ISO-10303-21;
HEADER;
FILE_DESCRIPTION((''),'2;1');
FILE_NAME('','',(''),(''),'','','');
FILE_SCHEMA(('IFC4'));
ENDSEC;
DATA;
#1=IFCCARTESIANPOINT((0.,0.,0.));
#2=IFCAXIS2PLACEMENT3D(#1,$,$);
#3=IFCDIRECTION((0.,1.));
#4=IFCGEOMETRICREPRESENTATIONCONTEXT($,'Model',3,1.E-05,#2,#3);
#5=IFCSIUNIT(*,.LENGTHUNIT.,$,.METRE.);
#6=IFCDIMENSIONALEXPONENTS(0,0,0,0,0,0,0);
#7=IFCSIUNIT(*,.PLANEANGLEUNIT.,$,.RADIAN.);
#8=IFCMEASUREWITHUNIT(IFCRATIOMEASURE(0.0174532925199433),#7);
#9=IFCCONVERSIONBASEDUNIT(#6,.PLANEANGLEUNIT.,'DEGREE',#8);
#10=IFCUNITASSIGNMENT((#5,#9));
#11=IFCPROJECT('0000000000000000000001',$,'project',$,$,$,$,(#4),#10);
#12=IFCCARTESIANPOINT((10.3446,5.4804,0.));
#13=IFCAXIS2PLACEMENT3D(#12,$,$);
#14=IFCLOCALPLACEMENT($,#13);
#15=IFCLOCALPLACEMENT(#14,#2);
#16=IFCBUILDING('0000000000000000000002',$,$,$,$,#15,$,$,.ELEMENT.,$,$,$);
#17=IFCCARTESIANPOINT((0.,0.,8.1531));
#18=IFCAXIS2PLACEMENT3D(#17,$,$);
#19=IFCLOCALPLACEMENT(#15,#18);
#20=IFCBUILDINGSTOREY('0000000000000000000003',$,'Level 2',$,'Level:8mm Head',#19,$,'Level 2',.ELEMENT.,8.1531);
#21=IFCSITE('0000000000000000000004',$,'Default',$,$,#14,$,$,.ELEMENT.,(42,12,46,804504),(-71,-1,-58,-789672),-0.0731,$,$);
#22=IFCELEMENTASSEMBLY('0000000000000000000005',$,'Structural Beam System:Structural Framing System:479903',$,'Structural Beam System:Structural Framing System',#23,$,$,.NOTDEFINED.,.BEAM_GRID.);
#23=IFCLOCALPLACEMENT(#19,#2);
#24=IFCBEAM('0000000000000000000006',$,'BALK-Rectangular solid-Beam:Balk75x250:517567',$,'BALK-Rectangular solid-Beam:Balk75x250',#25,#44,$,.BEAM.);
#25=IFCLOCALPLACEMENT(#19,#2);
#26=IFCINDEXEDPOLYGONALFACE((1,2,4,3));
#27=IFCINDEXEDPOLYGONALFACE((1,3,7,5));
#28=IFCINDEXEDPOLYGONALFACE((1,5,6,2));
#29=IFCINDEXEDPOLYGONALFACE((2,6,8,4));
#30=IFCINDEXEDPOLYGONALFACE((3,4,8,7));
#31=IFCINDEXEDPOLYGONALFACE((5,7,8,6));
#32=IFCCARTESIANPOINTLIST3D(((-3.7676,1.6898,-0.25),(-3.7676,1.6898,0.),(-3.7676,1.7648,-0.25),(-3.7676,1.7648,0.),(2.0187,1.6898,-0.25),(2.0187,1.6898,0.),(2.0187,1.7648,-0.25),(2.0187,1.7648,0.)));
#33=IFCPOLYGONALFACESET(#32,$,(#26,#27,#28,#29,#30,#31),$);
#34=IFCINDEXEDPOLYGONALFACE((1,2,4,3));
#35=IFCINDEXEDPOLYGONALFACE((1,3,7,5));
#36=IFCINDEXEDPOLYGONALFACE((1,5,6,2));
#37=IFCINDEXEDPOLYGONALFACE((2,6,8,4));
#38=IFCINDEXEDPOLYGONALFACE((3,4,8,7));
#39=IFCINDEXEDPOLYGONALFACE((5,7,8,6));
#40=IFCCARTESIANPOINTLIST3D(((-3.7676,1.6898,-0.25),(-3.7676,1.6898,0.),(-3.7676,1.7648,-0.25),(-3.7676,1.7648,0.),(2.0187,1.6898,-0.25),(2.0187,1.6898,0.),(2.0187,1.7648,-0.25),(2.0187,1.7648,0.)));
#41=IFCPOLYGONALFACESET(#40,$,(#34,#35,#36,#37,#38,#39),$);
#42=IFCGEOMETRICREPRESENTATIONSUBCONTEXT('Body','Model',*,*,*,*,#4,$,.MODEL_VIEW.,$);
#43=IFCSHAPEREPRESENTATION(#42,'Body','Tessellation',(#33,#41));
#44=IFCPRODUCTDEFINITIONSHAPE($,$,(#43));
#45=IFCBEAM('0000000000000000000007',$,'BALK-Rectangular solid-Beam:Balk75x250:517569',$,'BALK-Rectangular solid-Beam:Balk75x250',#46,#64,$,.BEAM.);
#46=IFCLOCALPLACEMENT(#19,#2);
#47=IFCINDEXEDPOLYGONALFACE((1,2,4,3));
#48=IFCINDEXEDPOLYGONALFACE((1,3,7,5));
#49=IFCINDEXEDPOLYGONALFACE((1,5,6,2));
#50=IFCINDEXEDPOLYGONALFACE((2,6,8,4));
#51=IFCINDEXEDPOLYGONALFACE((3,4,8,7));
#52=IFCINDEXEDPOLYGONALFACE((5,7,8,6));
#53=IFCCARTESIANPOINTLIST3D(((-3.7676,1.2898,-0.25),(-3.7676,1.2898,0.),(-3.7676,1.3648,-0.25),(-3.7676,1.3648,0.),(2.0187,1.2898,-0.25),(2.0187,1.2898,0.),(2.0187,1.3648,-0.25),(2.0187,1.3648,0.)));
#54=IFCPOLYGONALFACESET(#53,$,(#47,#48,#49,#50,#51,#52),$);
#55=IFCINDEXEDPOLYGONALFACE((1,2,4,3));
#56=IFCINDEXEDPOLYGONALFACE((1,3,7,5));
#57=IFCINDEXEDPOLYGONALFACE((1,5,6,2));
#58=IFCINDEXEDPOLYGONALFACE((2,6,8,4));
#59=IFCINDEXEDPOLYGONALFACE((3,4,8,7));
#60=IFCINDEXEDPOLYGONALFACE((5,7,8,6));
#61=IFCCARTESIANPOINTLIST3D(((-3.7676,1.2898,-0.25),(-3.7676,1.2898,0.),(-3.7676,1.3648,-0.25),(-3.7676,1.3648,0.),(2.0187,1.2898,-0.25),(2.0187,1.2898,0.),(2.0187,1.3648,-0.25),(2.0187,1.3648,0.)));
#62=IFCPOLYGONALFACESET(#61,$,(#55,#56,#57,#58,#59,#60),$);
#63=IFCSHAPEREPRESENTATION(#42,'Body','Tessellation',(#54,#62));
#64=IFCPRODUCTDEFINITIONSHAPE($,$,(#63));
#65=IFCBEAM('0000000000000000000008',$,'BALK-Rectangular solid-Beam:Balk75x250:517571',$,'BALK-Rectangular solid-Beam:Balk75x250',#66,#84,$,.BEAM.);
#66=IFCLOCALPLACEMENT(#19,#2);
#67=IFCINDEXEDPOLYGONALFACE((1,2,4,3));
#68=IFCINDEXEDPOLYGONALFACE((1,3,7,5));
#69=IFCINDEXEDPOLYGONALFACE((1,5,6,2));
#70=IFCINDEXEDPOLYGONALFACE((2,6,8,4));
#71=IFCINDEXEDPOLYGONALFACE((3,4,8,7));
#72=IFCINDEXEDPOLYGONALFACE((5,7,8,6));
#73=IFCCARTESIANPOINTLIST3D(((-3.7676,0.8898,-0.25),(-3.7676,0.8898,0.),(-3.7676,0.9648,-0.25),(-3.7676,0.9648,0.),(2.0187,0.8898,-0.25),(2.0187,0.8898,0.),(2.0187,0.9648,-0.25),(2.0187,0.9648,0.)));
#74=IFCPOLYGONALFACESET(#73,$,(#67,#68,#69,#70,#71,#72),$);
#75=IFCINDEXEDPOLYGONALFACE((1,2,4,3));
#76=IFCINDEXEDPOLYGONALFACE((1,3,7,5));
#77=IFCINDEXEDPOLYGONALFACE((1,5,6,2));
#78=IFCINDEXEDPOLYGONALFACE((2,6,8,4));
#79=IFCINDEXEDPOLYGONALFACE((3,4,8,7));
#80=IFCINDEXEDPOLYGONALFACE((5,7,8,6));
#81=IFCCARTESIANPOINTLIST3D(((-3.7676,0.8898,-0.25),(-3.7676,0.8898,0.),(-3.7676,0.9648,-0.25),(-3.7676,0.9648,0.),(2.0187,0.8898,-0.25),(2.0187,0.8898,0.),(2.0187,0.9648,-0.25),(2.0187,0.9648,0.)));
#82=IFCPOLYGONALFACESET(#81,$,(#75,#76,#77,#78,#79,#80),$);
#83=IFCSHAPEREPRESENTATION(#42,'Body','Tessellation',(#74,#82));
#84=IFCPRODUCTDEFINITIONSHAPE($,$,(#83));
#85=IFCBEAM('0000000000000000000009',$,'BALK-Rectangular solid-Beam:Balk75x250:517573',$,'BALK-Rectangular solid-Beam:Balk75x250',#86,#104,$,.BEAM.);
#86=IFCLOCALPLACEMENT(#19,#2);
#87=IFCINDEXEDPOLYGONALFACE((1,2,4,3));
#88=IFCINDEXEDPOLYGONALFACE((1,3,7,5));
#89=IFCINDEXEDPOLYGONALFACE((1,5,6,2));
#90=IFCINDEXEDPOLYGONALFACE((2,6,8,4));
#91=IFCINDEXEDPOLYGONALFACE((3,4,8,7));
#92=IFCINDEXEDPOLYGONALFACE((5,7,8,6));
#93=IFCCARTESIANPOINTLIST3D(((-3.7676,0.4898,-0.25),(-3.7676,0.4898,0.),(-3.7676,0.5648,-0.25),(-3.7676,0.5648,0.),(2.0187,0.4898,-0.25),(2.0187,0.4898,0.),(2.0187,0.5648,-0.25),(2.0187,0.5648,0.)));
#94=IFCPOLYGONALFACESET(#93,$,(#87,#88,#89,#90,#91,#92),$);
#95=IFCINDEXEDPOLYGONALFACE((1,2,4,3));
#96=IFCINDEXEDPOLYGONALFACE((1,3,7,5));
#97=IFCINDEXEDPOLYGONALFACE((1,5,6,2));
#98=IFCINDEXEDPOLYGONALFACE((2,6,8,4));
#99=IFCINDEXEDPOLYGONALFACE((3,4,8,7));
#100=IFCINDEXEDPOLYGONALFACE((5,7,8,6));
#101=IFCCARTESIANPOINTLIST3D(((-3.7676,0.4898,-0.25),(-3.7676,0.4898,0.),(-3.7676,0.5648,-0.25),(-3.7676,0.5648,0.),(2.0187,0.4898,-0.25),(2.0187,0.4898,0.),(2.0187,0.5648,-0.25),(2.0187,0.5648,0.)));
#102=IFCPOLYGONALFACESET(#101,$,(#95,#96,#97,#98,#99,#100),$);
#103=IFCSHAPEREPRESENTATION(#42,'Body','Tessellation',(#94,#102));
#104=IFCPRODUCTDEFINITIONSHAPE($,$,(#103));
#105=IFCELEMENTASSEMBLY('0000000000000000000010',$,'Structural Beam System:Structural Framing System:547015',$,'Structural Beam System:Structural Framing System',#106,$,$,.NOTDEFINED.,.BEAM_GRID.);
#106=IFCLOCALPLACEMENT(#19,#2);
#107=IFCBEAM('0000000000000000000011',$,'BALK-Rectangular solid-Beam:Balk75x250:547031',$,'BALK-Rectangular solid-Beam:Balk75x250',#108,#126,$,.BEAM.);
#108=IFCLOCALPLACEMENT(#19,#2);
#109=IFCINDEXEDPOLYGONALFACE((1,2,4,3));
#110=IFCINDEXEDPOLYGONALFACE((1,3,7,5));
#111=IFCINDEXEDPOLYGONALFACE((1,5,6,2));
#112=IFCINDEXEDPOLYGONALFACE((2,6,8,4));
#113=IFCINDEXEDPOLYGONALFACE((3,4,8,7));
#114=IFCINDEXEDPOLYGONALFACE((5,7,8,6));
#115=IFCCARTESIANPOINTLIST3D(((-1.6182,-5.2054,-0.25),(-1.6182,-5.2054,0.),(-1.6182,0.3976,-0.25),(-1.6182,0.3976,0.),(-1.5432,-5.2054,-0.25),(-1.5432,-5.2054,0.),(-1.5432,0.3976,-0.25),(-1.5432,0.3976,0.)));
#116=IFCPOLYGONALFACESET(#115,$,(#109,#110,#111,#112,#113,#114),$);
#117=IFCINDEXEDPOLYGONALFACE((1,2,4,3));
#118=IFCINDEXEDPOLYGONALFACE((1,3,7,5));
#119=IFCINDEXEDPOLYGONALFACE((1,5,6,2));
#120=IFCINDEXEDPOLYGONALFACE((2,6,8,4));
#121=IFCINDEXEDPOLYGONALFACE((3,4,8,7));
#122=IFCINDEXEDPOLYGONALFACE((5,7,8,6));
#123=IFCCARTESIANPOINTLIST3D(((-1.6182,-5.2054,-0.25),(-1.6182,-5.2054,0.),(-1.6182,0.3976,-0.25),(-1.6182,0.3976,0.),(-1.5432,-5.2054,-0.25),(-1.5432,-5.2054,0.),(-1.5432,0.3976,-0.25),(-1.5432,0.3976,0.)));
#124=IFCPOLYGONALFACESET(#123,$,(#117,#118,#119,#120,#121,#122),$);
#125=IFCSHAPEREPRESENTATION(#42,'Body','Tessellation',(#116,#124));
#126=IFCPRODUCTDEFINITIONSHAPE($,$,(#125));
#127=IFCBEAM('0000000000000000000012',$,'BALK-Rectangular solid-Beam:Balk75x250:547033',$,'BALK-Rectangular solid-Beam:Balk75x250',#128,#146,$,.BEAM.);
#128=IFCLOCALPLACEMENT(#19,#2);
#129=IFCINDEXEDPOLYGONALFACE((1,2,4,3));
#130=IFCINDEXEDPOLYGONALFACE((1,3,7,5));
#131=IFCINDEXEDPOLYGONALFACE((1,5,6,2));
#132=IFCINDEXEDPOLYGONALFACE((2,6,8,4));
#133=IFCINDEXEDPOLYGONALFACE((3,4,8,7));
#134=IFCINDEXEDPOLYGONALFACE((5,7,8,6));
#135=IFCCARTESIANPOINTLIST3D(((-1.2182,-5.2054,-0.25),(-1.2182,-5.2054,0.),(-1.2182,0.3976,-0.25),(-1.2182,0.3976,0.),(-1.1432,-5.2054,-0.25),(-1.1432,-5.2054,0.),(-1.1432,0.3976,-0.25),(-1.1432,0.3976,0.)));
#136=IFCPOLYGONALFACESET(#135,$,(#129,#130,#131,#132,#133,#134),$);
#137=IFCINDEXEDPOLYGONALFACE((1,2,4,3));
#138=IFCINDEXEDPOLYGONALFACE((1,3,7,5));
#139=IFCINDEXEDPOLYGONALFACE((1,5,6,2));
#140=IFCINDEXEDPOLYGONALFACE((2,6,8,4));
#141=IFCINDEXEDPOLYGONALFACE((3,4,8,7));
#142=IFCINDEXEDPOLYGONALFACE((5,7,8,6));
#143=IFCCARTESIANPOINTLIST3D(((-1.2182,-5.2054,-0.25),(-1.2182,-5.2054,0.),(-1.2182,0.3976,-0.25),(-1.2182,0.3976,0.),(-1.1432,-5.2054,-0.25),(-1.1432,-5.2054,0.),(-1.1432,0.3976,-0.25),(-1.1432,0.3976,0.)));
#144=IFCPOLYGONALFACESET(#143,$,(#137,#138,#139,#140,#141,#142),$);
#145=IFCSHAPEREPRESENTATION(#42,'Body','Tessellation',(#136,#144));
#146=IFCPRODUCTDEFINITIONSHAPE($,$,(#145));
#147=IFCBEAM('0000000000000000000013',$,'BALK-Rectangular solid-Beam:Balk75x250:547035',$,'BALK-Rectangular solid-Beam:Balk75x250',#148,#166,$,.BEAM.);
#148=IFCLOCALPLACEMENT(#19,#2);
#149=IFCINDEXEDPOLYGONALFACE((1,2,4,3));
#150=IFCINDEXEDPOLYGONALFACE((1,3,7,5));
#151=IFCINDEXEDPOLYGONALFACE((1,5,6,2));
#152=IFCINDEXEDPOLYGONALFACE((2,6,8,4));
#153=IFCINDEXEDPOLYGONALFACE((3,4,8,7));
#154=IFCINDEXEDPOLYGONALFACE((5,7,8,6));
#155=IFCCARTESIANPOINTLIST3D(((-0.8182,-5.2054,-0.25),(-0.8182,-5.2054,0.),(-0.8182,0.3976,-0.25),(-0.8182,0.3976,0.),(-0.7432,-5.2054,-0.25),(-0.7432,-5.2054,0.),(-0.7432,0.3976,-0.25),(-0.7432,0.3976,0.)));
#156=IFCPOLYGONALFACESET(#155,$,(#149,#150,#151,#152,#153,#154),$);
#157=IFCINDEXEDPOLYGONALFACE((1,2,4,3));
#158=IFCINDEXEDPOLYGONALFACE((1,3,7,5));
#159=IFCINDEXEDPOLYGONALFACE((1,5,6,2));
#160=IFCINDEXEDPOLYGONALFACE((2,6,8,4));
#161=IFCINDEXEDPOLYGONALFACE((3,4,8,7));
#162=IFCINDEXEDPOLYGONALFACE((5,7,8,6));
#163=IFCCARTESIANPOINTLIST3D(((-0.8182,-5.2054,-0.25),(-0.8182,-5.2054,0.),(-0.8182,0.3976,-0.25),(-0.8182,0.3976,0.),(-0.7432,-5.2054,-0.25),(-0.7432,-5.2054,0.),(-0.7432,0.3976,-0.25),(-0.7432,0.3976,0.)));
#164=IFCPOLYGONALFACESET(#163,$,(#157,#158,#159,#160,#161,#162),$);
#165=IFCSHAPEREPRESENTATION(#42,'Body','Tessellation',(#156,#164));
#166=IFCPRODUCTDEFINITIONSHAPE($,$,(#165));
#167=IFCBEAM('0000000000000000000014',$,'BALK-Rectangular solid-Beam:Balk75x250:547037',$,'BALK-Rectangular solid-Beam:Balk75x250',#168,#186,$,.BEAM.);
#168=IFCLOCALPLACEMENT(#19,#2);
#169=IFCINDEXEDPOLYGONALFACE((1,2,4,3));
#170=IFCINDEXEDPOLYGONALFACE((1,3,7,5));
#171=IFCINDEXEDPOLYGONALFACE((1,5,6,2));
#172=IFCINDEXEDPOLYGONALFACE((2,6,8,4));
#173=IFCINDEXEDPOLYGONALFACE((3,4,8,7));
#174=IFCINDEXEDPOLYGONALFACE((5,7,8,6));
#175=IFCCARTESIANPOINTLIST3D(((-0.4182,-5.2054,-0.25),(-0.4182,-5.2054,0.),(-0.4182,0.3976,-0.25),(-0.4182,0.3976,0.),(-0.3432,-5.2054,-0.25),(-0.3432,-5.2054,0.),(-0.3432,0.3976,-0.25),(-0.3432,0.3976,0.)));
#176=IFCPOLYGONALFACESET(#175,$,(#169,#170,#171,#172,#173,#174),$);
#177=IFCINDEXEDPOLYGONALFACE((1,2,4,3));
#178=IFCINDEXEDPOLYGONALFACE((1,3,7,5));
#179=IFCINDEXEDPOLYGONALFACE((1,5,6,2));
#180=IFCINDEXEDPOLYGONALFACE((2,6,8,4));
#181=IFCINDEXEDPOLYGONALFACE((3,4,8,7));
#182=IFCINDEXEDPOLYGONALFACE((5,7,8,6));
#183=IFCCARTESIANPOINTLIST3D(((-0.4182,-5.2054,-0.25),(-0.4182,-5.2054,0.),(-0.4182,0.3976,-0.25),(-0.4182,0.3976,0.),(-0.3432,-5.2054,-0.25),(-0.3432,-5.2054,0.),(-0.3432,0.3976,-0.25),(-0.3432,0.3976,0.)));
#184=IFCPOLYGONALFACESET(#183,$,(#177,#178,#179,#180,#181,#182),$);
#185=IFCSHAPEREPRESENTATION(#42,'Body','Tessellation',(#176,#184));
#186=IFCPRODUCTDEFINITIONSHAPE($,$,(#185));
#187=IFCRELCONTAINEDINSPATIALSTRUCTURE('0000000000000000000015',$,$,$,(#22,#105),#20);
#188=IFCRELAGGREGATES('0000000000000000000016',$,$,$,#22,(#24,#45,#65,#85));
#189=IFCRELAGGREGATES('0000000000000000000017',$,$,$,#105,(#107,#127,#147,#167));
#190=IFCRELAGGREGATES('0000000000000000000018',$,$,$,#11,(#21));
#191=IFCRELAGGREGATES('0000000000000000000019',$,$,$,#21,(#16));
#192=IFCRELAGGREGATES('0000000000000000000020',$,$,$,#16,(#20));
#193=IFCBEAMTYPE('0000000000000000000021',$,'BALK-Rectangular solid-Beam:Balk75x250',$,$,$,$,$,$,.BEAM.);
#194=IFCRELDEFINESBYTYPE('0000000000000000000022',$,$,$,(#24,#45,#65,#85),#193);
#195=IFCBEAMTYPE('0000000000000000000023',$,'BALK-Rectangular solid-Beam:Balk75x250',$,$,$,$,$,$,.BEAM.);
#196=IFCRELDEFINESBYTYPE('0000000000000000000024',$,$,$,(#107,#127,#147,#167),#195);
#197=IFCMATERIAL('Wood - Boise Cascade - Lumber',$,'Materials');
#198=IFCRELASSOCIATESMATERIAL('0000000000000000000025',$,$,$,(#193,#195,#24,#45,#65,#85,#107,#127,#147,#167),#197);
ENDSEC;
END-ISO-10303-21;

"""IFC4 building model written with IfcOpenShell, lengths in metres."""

from ifc_helpers import new_model, entity, si_unit, converted_unit, direction, frame, frame_2d, origin, origin_2d_with_axis, place, context, subcontext, project, spatial, rectangle, extrude, source, transform, mapped, material, material_profile, profile_set, profile_usage, type_object, type_shapes, element, aggregate, save


model = new_model("IFC4")

# Units and contexts
model_context = context("Model", 3, precision=1e-05, world=origin(), true_north=direction((0.0, 1.0)))
body_context = subcontext(model_context, "Body", "Model", "MODEL_VIEW")
ifc_project = project(units=[si_unit("LENGTHUNIT", "METRE"), converted_unit("PLANEANGLEUNIT", "DEGREE", entity("IfcRatioMeasure", 0.0174532925199433), si_unit("PLANEANGLEUNIT", "RADIAN"), dimensions=[0, 0, 0, 0, 0, 0, 0])], contexts=[model_context])

# Site, building, storey
site_placement = place(None, frame((10.3446, 5.4804, 0.0)))
site = spatial("IfcSite", under=ifc_project, at=site_placement, Name="Default", CompositionType="ELEMENT", RefLatitude=(42, 12, 46, 804504), RefLongitude=(-71, -1, -58, -789672), RefElevation=-0.0731)
building_placement = place(site_placement, origin())
building = spatial("IfcBuilding", under=site, at=building_placement, CompositionType="ELEMENT")
storey_placement = place(building_placement, frame((0.0, 0.0, 8.1531)))
storey = spatial("IfcBuildingStorey", under=building, at=storey_placement, Name="Level 2", ObjectType="Level:8mm Head", LongName="Level 2", CompositionType="ELEMENT", Elevation=8.1531)

# Element assemblies, beams
ifc_material = material(Name="Wood - Boise Cascade - Lumber", Category="Materials")
ifc_material_profile = material_profile(ifc_material, rectangle(XDim=0.25, YDim=0.075, at=frame_2d((0.0, 0.0), x_axis=(1.0, 0.0))), Name="Balk75x250")
ifc_profile_set = profile_set([ifc_material_profile], Name="Balk75x250")
assembly_1_placement = place(storey_placement, origin())
assembly_1 = element("IfcElementAssembly", 1, at=assembly_1_placement, inside=storey, Name="Structural Beam System:Structural Framing System:479903", ObjectType="Structural Beam System:Structural Framing System", AssemblyPlace="NOTDEFINED", PredefinedType="BEAM_GRID")
beam_type_1 = type_object("IfcBeamType", Name="BALK-Rectangular solid-Beam:Balk75x250", PredefinedType="BEAM", material=ifc_profile_set)
shared_shape_1 = source(origin(), body_context, "Body", "SweptSolid", [
    extrude(rectangle(XDim=0.25, YDim=0.075, at=origin_2d_with_axis()), frame((-2.9869, 0.0, 0.0), z_axis=(1.0, 0.0, 0.0), x_axis=(0.0, 0.0, -1.0)), (0.0, 0.0, 1.0), 5.7863),
    extrude(rectangle(XDim=0.25, YDim=0.075, at=origin_2d_with_axis()), frame((-2.9869, 0.0, 0.0), z_axis=(1.0, 0.0, 0.0), x_axis=(0.0, 0.0, -1.0)), (0.0, 0.0, 1.0), 5.7863),
])
type_shapes(beam_type_1, [shared_shape_1])
ifc_profile_usage_1 = profile_usage(ifc_profile_set, cardinal=8)
beam_1_placement = place(assembly_1_placement, frame((-0.7807, 1.7273, -0.125)))
beam_1 = element("IfcBeam", 2, at=beam_1_placement, type_object=beam_type_1, material=ifc_profile_usage_1, Name="BALK-Rectangular solid-Beam:Balk75x250:517567", ObjectType="BALK-Rectangular solid-Beam:Balk75x250", PredefinedType="BEAM", context=body_context, shape_type="MappedRepresentation", body=[
    mapped(shared_shape_1, transform((0.0, 0.0, 0.0), scale=1.0)),
])
ifc_profile_usage_2 = profile_usage(ifc_profile_set, cardinal=8)
beam_2_placement = place(assembly_1_placement, frame((-0.7807, 1.3273, -0.125)))
beam_2 = element("IfcBeam", 3, at=beam_2_placement, type_object=beam_type_1, material=ifc_profile_usage_2, Name="BALK-Rectangular solid-Beam:Balk75x250:517569", ObjectType="BALK-Rectangular solid-Beam:Balk75x250", PredefinedType="BEAM", context=body_context, shape_type="MappedRepresentation", body=[
    mapped(shared_shape_1, transform((0.0, 0.0, 0.0), scale=1.0)),
])
ifc_profile_usage_3 = profile_usage(ifc_profile_set, cardinal=8)
beam_3_placement = place(assembly_1_placement, frame((-0.7807, 0.9273, -0.125)))
beam_3 = element("IfcBeam", 4, at=beam_3_placement, type_object=beam_type_1, material=ifc_profile_usage_3, Name="BALK-Rectangular solid-Beam:Balk75x250:517571", ObjectType="BALK-Rectangular solid-Beam:Balk75x250", PredefinedType="BEAM", context=body_context, shape_type="MappedRepresentation", body=[
    mapped(shared_shape_1, transform((0.0, 0.0, 0.0), scale=1.0)),
])
ifc_profile_usage_4 = profile_usage(ifc_profile_set, cardinal=8)
beam_4_placement = place(assembly_1_placement, frame((-0.7807, 0.5273, -0.125)))
beam_4 = element("IfcBeam", 5, at=beam_4_placement, type_object=beam_type_1, material=ifc_profile_usage_4, Name="BALK-Rectangular solid-Beam:Balk75x250:517573", ObjectType="BALK-Rectangular solid-Beam:Balk75x250", PredefinedType="BEAM", context=body_context, shape_type="MappedRepresentation", body=[
    mapped(shared_shape_1, transform((0.0, 0.0, 0.0), scale=1.0)),
])
aggregate(assembly_1, [beam_1, beam_2, beam_3, beam_4])
assembly_2_placement = place(storey_placement, origin())
assembly_2 = element("IfcElementAssembly", 6, at=assembly_2_placement, inside=storey, Name="Structural Beam System:Structural Framing System:547015", ObjectType="Structural Beam System:Structural Framing System", AssemblyPlace="NOTDEFINED", PredefinedType="BEAM_GRID")
ifc_profile_usage_5 = profile_usage(ifc_profile_set, cardinal=8)
beam_type_2 = type_object("IfcBeamType", Name="BALK-Rectangular solid-Beam:Balk75x250", PredefinedType="BEAM", material=ifc_profile_set)
shared_shape_2 = source(origin(), body_context, "Body", "SweptSolid", [
    extrude(rectangle(XDim=0.25, YDim=0.075, at=origin_2d_with_axis()), frame((-2.6953, 0.0, 0.0), z_axis=(1.0, 0.0, 0.0), x_axis=(0.0, 0.0, -1.0)), (0.0, 0.0, 1.0), 5.603),
    extrude(rectangle(XDim=0.25, YDim=0.075, at=origin_2d_with_axis()), frame((-2.6953, 0.0, 0.0), z_axis=(1.0, 0.0, 0.0), x_axis=(0.0, 0.0, -1.0)), (0.0, 0.0, 1.0), 5.603),
])
type_shapes(beam_type_2, [shared_shape_2])
beam_5_placement = place(assembly_2_placement, frame((-1.5807, -2.5102, -0.125), z_axis=(0.0, 0.0, 1.0), x_axis=(0.0, 1.0, 0.0)))
beam_5 = element("IfcBeam", 7, at=beam_5_placement, type_object=beam_type_2, material=ifc_profile_usage_5, Name="BALK-Rectangular solid-Beam:Balk75x250:547031", ObjectType="BALK-Rectangular solid-Beam:Balk75x250", PredefinedType="BEAM", context=body_context, shape_type="MappedRepresentation", body=[
    mapped(shared_shape_2, transform((0.0, 0.0, 0.0), scale=1.0)),
])
ifc_profile_usage_6 = profile_usage(ifc_profile_set, cardinal=8)
beam_6_placement = place(assembly_2_placement, frame((-1.1807, -2.5102, -0.125), z_axis=(0.0, 0.0, 1.0), x_axis=(0.0, 1.0, 0.0)))
beam_6 = element("IfcBeam", 8, at=beam_6_placement, type_object=beam_type_2, material=ifc_profile_usage_6, Name="BALK-Rectangular solid-Beam:Balk75x250:547033", ObjectType="BALK-Rectangular solid-Beam:Balk75x250", PredefinedType="BEAM", context=body_context, shape_type="MappedRepresentation", body=[
    mapped(shared_shape_2, transform((0.0, 0.0, 0.0), scale=1.0)),
])
ifc_profile_usage_7 = profile_usage(ifc_profile_set, cardinal=8)
beam_7_placement = place(assembly_2_placement, frame((-0.7807, -2.5102, -0.125), z_axis=(0.0, 0.0, 1.0), x_axis=(0.0, 1.0, 0.0)))
beam_7 = element("IfcBeam", 9, at=beam_7_placement, type_object=beam_type_2, material=ifc_profile_usage_7, Name="BALK-Rectangular solid-Beam:Balk75x250:547035", ObjectType="BALK-Rectangular solid-Beam:Balk75x250", PredefinedType="BEAM", context=body_context, shape_type="MappedRepresentation", body=[
    mapped(shared_shape_2, transform((0.0, 0.0, 0.0), scale=1.0)),
])
ifc_profile_usage_8 = profile_usage(ifc_profile_set, cardinal=8)
beam_8_placement = place(assembly_2_placement, frame((-0.3807, -2.5102, -0.125), z_axis=(0.0, 0.0, 1.0), x_axis=(0.0, 1.0, 0.0)))
beam_8 = element("IfcBeam", 10, at=beam_8_placement, type_object=beam_type_2, material=ifc_profile_usage_8, Name="BALK-Rectangular solid-Beam:Balk75x250:547037", ObjectType="BALK-Rectangular solid-Beam:Balk75x250", PredefinedType="BEAM", context=body_context, shape_type="MappedRepresentation", body=[
    mapped(shared_shape_2, transform((0.0, 0.0, 0.0), scale=1.0)),
])
aggregate(assembly_2, [beam_5, beam_6, beam_7, beam_8])

save(model, "model.ifc")
